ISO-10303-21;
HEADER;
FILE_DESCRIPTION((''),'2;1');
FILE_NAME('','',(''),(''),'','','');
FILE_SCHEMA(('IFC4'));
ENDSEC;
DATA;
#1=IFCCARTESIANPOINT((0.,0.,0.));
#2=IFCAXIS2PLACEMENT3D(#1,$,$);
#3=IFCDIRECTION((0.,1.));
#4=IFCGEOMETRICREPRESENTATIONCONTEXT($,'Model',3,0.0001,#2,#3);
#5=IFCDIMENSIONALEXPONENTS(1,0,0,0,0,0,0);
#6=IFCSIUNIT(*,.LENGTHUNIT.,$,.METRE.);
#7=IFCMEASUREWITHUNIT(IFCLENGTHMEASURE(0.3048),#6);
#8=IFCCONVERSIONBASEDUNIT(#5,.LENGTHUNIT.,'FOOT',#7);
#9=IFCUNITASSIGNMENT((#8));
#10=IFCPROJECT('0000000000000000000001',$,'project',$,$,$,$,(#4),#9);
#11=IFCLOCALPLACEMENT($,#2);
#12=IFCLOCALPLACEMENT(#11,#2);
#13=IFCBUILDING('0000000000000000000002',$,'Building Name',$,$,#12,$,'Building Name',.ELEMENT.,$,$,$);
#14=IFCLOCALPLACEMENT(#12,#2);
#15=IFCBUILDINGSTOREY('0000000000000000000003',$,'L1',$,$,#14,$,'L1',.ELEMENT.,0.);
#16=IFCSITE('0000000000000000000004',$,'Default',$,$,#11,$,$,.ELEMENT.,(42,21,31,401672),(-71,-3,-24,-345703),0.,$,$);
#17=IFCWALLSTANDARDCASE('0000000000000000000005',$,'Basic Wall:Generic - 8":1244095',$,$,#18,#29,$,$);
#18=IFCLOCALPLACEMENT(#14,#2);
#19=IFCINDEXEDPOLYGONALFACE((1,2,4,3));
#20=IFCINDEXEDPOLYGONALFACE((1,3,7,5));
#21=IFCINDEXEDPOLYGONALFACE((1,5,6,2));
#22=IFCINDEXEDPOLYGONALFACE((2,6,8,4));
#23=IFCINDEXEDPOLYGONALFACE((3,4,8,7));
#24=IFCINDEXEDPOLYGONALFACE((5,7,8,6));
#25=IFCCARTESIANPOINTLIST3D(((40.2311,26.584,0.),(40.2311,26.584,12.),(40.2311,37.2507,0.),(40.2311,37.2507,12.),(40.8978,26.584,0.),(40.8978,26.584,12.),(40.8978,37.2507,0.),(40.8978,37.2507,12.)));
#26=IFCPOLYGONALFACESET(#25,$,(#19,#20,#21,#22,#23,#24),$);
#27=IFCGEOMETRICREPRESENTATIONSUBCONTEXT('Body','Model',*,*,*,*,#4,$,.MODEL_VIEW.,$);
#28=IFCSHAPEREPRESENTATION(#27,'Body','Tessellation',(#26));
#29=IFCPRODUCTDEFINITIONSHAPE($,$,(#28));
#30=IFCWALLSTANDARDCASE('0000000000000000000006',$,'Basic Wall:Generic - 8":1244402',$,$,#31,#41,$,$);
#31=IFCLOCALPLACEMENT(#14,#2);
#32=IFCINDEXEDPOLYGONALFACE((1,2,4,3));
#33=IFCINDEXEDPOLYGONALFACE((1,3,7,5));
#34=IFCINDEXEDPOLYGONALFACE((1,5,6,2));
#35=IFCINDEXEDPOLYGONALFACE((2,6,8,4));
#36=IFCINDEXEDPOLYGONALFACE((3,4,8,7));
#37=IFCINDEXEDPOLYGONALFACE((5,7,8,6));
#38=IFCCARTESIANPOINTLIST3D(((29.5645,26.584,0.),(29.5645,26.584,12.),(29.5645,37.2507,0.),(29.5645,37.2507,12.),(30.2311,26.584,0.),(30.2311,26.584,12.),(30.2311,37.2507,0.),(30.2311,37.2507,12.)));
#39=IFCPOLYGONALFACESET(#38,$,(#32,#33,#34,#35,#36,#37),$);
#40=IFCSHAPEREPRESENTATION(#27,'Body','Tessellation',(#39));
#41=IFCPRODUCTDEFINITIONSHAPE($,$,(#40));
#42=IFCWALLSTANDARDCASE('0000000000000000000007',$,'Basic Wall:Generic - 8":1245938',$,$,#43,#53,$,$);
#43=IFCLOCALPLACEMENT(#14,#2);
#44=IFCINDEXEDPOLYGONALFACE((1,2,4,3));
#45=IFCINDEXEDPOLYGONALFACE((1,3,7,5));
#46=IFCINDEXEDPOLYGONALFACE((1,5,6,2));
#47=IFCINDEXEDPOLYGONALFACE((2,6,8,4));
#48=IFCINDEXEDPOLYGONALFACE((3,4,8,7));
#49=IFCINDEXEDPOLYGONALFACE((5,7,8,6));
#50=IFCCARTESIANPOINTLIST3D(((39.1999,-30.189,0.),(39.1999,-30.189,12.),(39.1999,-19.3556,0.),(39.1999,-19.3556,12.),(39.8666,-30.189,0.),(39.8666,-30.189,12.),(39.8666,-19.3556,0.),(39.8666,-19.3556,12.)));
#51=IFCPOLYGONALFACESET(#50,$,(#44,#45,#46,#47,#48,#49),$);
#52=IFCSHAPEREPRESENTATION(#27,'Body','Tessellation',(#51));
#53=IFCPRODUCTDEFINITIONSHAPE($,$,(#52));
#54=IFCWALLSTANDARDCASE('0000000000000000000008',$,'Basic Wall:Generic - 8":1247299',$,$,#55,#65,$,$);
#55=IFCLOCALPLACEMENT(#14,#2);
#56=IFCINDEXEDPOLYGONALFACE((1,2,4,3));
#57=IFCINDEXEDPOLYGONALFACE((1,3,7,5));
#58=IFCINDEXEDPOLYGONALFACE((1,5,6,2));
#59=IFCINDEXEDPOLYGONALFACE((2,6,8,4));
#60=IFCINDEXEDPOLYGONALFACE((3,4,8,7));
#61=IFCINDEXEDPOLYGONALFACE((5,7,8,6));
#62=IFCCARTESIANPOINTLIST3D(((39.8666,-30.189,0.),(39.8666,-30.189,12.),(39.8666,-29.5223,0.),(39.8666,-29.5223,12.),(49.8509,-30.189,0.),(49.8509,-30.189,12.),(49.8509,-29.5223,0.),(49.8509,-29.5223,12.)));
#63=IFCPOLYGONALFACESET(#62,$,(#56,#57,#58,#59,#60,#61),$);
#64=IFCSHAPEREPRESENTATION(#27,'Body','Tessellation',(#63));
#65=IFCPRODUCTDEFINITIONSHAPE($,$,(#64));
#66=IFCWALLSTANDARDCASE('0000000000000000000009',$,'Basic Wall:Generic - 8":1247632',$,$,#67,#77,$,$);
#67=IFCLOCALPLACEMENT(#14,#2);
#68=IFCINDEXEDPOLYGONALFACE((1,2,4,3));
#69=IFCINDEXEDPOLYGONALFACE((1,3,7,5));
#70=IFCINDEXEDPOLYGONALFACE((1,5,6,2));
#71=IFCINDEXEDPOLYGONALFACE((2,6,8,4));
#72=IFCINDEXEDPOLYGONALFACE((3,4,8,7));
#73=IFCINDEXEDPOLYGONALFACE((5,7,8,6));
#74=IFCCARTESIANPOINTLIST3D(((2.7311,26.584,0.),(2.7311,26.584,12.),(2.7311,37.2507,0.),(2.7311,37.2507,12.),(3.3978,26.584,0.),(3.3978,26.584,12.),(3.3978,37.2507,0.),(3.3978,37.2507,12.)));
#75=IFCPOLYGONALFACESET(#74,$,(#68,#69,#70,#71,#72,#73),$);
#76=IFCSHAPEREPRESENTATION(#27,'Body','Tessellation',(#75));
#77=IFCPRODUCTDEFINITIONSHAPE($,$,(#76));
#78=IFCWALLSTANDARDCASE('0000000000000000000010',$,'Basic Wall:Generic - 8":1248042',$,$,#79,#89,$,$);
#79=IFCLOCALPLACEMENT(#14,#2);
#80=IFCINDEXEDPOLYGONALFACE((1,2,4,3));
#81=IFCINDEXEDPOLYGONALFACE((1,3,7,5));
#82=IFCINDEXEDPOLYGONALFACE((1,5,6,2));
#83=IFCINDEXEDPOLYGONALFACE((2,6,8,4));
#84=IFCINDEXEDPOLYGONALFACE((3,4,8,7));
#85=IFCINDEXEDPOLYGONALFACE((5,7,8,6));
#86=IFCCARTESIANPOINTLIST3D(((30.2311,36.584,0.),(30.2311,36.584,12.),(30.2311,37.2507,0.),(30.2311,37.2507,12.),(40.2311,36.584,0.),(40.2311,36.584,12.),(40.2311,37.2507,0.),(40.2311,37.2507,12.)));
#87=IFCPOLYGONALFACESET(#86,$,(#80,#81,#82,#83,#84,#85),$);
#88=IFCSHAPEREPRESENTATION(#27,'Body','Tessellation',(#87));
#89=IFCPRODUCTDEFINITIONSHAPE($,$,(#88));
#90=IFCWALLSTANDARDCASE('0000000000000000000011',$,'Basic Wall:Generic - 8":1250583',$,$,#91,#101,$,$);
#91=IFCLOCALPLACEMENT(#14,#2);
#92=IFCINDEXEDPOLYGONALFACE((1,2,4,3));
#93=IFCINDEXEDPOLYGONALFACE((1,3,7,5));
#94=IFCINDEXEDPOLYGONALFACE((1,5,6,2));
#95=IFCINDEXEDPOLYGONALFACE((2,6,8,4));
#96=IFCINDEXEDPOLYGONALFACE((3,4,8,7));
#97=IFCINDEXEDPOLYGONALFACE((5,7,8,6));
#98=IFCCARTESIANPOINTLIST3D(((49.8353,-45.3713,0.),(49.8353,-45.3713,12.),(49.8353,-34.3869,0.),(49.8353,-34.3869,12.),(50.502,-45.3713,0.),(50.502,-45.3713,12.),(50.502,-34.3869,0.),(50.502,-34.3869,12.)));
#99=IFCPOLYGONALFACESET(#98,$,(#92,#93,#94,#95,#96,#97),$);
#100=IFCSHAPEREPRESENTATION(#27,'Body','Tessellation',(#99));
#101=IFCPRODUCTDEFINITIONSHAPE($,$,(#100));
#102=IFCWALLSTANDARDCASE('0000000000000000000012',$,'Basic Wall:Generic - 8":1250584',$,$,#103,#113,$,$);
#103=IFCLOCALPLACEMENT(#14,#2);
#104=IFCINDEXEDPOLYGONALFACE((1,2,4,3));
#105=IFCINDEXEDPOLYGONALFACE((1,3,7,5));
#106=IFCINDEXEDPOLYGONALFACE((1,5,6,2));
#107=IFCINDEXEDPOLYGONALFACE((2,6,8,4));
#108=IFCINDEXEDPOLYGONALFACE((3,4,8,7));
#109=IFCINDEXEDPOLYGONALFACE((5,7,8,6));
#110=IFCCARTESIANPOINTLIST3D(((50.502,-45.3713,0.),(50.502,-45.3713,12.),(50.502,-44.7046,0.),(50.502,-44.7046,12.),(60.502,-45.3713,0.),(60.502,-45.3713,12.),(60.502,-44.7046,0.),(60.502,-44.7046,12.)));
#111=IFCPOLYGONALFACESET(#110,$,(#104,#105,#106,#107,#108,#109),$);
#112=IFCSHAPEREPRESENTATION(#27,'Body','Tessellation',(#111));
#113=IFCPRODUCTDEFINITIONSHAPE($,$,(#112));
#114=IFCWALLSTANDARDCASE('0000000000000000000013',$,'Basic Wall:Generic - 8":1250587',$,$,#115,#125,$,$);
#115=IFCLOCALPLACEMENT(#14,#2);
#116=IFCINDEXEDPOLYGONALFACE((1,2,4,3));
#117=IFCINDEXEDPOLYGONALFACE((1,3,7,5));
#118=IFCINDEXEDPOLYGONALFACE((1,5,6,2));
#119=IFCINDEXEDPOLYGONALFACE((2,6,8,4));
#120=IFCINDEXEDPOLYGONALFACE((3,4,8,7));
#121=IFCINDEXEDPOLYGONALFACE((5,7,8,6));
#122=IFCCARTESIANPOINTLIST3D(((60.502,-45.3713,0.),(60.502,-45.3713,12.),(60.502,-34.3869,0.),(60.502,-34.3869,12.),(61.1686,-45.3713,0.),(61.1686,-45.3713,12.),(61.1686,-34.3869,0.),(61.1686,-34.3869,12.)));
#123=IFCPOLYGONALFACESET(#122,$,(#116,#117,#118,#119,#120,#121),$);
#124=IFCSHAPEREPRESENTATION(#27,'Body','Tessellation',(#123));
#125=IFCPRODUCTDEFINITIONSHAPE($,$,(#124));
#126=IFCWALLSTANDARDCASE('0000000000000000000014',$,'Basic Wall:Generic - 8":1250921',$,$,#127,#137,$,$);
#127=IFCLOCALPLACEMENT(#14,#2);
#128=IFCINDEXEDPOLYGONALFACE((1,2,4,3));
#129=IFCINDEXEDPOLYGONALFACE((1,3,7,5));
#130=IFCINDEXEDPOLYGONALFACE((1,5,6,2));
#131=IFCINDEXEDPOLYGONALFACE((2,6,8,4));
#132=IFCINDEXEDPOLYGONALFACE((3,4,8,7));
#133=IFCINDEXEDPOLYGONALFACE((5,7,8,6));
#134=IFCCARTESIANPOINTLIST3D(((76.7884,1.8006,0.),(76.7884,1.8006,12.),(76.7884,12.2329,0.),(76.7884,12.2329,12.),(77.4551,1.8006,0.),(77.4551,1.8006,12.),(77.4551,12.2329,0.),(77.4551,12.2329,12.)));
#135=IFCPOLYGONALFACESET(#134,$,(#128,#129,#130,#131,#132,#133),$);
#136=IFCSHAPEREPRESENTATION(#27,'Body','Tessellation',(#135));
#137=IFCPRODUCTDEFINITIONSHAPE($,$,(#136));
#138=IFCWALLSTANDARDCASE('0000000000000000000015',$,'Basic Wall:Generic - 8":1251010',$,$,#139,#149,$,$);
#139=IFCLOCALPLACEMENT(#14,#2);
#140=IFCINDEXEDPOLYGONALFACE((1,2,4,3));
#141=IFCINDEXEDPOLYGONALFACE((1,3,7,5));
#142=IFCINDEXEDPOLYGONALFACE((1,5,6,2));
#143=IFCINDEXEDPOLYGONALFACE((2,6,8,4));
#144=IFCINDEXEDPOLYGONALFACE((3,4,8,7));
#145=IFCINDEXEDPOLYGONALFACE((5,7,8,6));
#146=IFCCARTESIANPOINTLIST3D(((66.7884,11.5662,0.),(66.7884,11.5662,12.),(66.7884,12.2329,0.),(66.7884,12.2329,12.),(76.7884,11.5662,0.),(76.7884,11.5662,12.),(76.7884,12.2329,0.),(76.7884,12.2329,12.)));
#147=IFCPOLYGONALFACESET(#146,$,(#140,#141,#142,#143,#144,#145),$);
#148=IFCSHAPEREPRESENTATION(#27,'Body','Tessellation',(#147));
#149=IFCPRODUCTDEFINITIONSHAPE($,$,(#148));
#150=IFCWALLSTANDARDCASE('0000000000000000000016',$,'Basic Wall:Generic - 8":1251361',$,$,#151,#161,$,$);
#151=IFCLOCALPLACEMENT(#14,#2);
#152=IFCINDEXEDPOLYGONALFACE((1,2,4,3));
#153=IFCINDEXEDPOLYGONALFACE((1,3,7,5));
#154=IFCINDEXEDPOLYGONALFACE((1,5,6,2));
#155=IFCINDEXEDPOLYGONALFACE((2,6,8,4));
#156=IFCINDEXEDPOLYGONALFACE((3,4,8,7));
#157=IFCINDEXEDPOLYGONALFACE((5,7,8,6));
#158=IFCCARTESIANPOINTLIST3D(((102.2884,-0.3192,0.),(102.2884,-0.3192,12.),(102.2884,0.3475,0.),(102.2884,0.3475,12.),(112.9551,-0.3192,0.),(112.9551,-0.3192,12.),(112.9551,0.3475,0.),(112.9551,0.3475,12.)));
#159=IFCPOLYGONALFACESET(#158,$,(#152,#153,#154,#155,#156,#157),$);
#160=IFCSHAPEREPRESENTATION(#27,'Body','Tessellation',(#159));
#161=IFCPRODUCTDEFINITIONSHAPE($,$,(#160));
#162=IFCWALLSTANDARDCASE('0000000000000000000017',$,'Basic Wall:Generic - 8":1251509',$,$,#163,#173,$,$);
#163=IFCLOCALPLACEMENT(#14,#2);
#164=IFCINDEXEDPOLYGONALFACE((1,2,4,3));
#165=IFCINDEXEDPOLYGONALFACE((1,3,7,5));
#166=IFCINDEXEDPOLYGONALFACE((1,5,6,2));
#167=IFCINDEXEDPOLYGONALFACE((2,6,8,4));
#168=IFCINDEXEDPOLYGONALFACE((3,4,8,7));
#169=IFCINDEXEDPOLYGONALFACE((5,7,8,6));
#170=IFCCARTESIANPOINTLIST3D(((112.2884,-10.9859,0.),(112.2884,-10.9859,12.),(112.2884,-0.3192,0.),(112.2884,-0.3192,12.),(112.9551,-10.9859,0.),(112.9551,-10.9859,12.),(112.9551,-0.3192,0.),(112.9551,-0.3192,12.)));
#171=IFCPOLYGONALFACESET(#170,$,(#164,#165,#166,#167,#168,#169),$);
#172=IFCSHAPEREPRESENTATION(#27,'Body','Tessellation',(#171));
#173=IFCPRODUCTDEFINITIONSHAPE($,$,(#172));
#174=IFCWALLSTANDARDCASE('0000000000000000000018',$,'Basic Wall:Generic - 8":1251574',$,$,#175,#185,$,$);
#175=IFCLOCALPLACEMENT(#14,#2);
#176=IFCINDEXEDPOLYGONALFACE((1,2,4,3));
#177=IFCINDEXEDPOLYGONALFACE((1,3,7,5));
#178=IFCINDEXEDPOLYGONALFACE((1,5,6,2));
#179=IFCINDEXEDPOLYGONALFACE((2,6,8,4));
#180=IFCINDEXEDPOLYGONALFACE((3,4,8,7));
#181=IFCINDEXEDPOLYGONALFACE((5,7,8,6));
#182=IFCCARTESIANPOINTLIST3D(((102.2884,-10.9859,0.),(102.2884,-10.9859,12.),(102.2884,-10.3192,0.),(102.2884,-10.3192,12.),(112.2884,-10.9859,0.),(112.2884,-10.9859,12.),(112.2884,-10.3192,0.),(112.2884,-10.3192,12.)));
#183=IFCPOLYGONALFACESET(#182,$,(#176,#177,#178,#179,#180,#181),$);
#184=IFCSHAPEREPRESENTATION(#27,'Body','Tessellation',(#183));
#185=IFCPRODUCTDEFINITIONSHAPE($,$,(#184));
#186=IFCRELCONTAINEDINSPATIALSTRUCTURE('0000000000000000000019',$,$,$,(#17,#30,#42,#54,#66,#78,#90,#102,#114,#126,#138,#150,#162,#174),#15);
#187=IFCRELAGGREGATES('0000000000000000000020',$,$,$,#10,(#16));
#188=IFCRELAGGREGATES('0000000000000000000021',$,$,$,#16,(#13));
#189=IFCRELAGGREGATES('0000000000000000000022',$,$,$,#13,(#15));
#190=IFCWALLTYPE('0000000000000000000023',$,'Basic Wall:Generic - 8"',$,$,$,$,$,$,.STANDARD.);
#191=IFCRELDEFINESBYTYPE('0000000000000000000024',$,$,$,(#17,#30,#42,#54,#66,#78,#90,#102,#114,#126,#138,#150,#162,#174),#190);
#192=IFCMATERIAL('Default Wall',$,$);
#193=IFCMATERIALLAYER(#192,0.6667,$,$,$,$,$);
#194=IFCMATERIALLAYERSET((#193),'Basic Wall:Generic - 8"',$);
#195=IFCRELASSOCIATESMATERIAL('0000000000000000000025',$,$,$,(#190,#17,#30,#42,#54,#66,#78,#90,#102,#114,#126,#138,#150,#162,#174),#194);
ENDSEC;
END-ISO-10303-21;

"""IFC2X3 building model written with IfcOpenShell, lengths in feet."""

from ifc_helpers import new_model, entity, si_unit, converted_unit, direction, frame, frame_2d, origin, place, context, subcontext, project, spatial, rectangle, extrude, material, layer, layer_set, layer_usage, type_object, element, save


model = new_model("IFC2X3")

# Units and contexts
model_context = context("Model", 3, precision=0.0001, world=origin(), true_north=direction((0.0, 1.0)))
body_context = subcontext(model_context, "Body", "Model", "MODEL_VIEW")
ifc_project = project(units=[converted_unit("LENGTHUNIT", "FOOT", entity("IfcLengthMeasure", 0.3048), si_unit("LENGTHUNIT", "METRE"), dimensions=[1, 0, 0, 0, 0, 0, 0])], contexts=[model_context])

# Site, building, storey
site_placement = place(None, origin())
site = spatial("IfcSite", under=ifc_project, at=site_placement, Name="Default", CompositionType="ELEMENT", RefLatitude=(42, 21, 31, 401672), RefLongitude=(-71, -3, -24, -345703), RefElevation=0.0)
building_placement = place(site_placement, origin())
building = spatial("IfcBuilding", under=site, at=building_placement, Name="Building Name", LongName="Building Name", CompositionType="ELEMENT")
storey_placement = place(building_placement, origin())
storey = spatial("IfcBuildingStorey", under=building, at=storey_placement, Name="L1", LongName="L1", CompositionType="ELEMENT", Elevation=0.0)

# Walls
ifc_material_1 = material(Name="Default Wall")
ifc_layer_1 = layer(ifc_material_1, 0.6667)
ifc_layer_set_1 = layer_set([ifc_layer_1], Name="Basic Wall:Generic - 8\"")
ifc_layer_usage_1 = layer_usage(ifc_layer_set_1, "AXIS2", "POSITIVE", -0.3333)
wall_type_1 = type_object("IfcWallType", Name="Basic Wall:Generic - 8\"", PredefinedType="STANDARD", material=ifc_layer_set_1)
wall_1_placement = place(storey_placement, frame((40.5645, 26.584, 0.0), z_axis=(0.0, 0.0, 1.0), x_axis=(0.0, 1.0, 0.0)))
element("IfcWallStandardCase", 1, at=wall_1_placement, inside=storey, type_object=wall_type_1, material=ifc_layer_usage_1, Name="Basic Wall:Generic - 8\":1244095", context=body_context, shape_type="SweptSolid", body=[
    extrude(rectangle(XDim=10.6667, YDim=0.6667, at=frame_2d((5.3333, 0.0), x_axis=(-1.0, 0.0))), origin(), (0.0, 0.0, 1.0), 12.0),
])
ifc_layer_usage_2 = layer_usage(ifc_layer_set_1, "AXIS2", "NEGATIVE", 0.3333)
wall_2_placement = place(storey_placement, frame((29.8978, 26.584, 0.0), z_axis=(0.0, 0.0, 1.0), x_axis=(0.0, 1.0, 0.0)))
element("IfcWallStandardCase", 2, at=wall_2_placement, inside=storey, type_object=wall_type_1, material=ifc_layer_usage_2, Name="Basic Wall:Generic - 8\":1244402", context=body_context, shape_type="SweptSolid", body=[
    extrude(rectangle(XDim=10.6667, YDim=0.6667, at=frame_2d((5.3333, 0.0), x_axis=(-1.0, 0.0))), origin(), (0.0, 0.0, 1.0), 12.0),
])
ifc_layer_usage_3 = layer_usage(ifc_layer_set_1, "AXIS2", "POSITIVE", -0.3333)
wall_3_placement = place(storey_placement, frame((39.5332, -19.3556, 0.0), z_axis=(0.0, 0.0, 1.0), x_axis=(0.0, -1.0, 0.0)))
element("IfcWallStandardCase", 3, at=wall_3_placement, inside=storey, type_object=wall_type_1, material=ifc_layer_usage_3, Name="Basic Wall:Generic - 8\":1245938", context=body_context, shape_type="SweptSolid", body=[
    extrude(rectangle(XDim=10.8333, YDim=0.6667, at=frame_2d((5.4167, 0.0), x_axis=(-1.0, 0.0))), origin(), (0.0, 0.0, 1.0), 12.0),
])
ifc_layer_usage_4 = layer_usage(ifc_layer_set_1, "AXIS2", "NEGATIVE", 0.3333)
wall_4_placement = place(storey_placement, frame((39.8666, -29.8556, 0.0)))
element("IfcWallStandardCase", 4, at=wall_4_placement, inside=storey, type_object=wall_type_1, material=ifc_layer_usage_4, Name="Basic Wall:Generic - 8\":1247299", context=body_context, shape_type="SweptSolid", body=[
    extrude(rectangle(XDim=9.9844, YDim=0.6667, at=frame_2d((4.9922, 0.0), x_axis=(-1.0, 0.0))), origin(), (0.0, 0.0, 1.0), 12.0),
])
ifc_layer_usage_5 = layer_usage(ifc_layer_set_1, "AXIS2", "NEGATIVE", 0.3333)
wall_5_placement = place(storey_placement, frame((3.0645, 37.2507, 0.0), z_axis=(0.0, 0.0, 1.0), x_axis=(0.0, -1.0, 0.0)))
element("IfcWallStandardCase", 5, at=wall_5_placement, inside=storey, type_object=wall_type_1, material=ifc_layer_usage_5, Name="Basic Wall:Generic - 8\":1247632", context=body_context, shape_type="SweptSolid", body=[
    extrude(rectangle(XDim=10.6667, YDim=0.6667, at=frame_2d((5.3333, 0.0), x_axis=(-1.0, 0.0))), origin(), (0.0, 0.0, 1.0), 12.0),
])
ifc_layer_usage_6 = layer_usage(ifc_layer_set_1, "AXIS2", "NEGATIVE", 0.3333)
wall_6_placement = place(storey_placement, frame((30.2311, 36.9174, 0.0)))
element("IfcWallStandardCase", 6, at=wall_6_placement, inside=storey, type_object=wall_type_1, material=ifc_layer_usage_6, Name="Basic Wall:Generic - 8\":1248042", context=body_context, shape_type="SweptSolid", body=[
    extrude(rectangle(XDim=10.0, YDim=0.6667, at=frame_2d((5.0, 0.0), x_axis=(-1.0, 0.0))), origin(), (0.0, 0.0, 1.0), 12.0),
])
ifc_layer_usage_7 = layer_usage(ifc_layer_set_1, "AXIS2", "POSITIVE", -0.3333)
wall_7_placement = place(storey_placement, frame((50.1686, -34.3869, 0.0), z_axis=(0.0, 0.0, 1.0), x_axis=(0.0, -1.0, 0.0)))
element("IfcWallStandardCase", 7, at=wall_7_placement, inside=storey, type_object=wall_type_1, material=ifc_layer_usage_7, Name="Basic Wall:Generic - 8\":1250583", context=body_context, shape_type="SweptSolid", body=[
    extrude(rectangle(XDim=10.9844, YDim=0.6667, at=frame_2d((5.4922, 0.0), x_axis=(-1.0, 0.0))), origin(), (0.0, 0.0, 1.0), 12.0),
])
ifc_layer_usage_8 = layer_usage(ifc_layer_set_1, "AXIS2", "POSITIVE", -0.3333)
wall_8_placement = place(storey_placement, frame((50.502, -45.0379, 0.0)))
element("IfcWallStandardCase", 8, at=wall_8_placement, inside=storey, type_object=wall_type_1, material=ifc_layer_usage_8, Name="Basic Wall:Generic - 8\":1250584", context=body_context, shape_type="SweptSolid", body=[
    extrude(rectangle(XDim=10.0, YDim=0.6667, at=frame_2d((5.0, 0.0), x_axis=(-1.0, 0.0))), origin(), (0.0, 0.0, 1.0), 12.0),
])
ifc_layer_usage_9 = layer_usage(ifc_layer_set_1, "AXIS2", "NEGATIVE", 0.3333)
wall_9_placement = place(storey_placement, frame((60.8353, -34.3869, 0.0), z_axis=(0.0, 0.0, 1.0), x_axis=(0.0, -1.0, 0.0)))
element("IfcWallStandardCase", 9, at=wall_9_placement, inside=storey, type_object=wall_type_1, material=ifc_layer_usage_9, Name="Basic Wall:Generic - 8\":1250587", context=body_context, shape_type="SweptSolid", body=[
    extrude(rectangle(XDim=10.9844, YDim=0.6667, at=frame_2d((5.4922, 0.0), x_axis=(-1.0, 0.0))), origin(), (0.0, 0.0, 1.0), 12.0),
])
ifc_layer_usage_10 = layer_usage(ifc_layer_set_1, "AXIS2", "NEGATIVE", 0.3333)
wall_10_placement = place(storey_placement, frame((77.1218, 1.8006, 0.0), z_axis=(0.0, 0.0, 1.0), x_axis=(0.0, 1.0, 0.0)))
element("IfcWallStandardCase", 10, at=wall_10_placement, inside=storey, type_object=wall_type_1, material=ifc_layer_usage_10, Name="Basic Wall:Generic - 8\":1250921", context=body_context, shape_type="SweptSolid", body=[
    extrude(rectangle(XDim=10.4323, YDim=0.6667, at=frame_2d((5.2161, 0.0), x_axis=(-1.0, 0.0))), origin(), (0.0, 0.0, 1.0), 12.0),
])
ifc_layer_usage_11 = layer_usage(ifc_layer_set_1, "AXIS2", "NEGATIVE", 0.3333)
wall_11_placement = place(storey_placement, frame((76.7884, 11.8996, 0.0), z_axis=(0.0, 0.0, 1.0), x_axis=(-1.0, 0.0, 0.0)))
element("IfcWallStandardCase", 11, at=wall_11_placement, inside=storey, type_object=wall_type_1, material=ifc_layer_usage_11, Name="Basic Wall:Generic - 8\":1251010", context=body_context, shape_type="SweptSolid", body=[
    extrude(rectangle(XDim=10.0, YDim=0.6667, at=frame_2d((5.0, 0.0), x_axis=(-1.0, 0.0))), origin(), (0.0, 0.0, 1.0), 12.0),
])
ifc_layer_usage_12 = layer_usage(ifc_layer_set_1, "AXIS2", "NEGATIVE", 0.3333)
wall_12_placement = place(storey_placement, frame((102.2884, 0.0141, 0.0)))
element("IfcWallStandardCase", 12, at=wall_12_placement, inside=storey, type_object=wall_type_1, material=ifc_layer_usage_12, Name="Basic Wall:Generic - 8\":1251361", context=body_context, shape_type="SweptSolid", body=[
    extrude(rectangle(XDim=10.6667, YDim=0.6667, at=frame_2d((5.3333, 0.0), x_axis=(-1.0, 0.0))), origin(), (0.0, 0.0, 1.0), 12.0),
])
ifc_layer_usage_13 = layer_usage(ifc_layer_set_1, "AXIS2", "POSITIVE", -0.3333)
wall_13_placement = place(storey_placement, frame((112.6218, -0.3192, 0.0), z_axis=(0.0, 0.0, 1.0), x_axis=(0.0, -1.0, 0.0)))
element("IfcWallStandardCase", 13, at=wall_13_placement, inside=storey, type_object=wall_type_1, material=ifc_layer_usage_13, Name="Basic Wall:Generic - 8\":1251509", context=body_context, shape_type="SweptSolid", body=[
    extrude(rectangle(XDim=10.6667, YDim=0.6667, at=frame_2d((5.3333, 0.0), x_axis=(-1.0, 0.0))), origin(), (0.0, 0.0, 1.0), 12.0),
])
ifc_layer_usage_14 = layer_usage(ifc_layer_set_1, "AXIS2", "NEGATIVE", 0.3333)
wall_14_placement = place(storey_placement, frame((112.2884, -10.6525, 0.0), z_axis=(0.0, 0.0, 1.0), x_axis=(-1.0, 0.0, 0.0)))
element("IfcWallStandardCase", 14, at=wall_14_placement, inside=storey, type_object=wall_type_1, material=ifc_layer_usage_14, Name="Basic Wall:Generic - 8\":1251574", context=body_context, shape_type="SweptSolid", body=[
    extrude(rectangle(XDim=10.0, YDim=0.6667, at=frame_2d((5.0, 0.0), x_axis=(-1.0, 0.0))), origin(), (0.0, 0.0, 1.0), 12.0),
])

save(model, "model.ifc")
